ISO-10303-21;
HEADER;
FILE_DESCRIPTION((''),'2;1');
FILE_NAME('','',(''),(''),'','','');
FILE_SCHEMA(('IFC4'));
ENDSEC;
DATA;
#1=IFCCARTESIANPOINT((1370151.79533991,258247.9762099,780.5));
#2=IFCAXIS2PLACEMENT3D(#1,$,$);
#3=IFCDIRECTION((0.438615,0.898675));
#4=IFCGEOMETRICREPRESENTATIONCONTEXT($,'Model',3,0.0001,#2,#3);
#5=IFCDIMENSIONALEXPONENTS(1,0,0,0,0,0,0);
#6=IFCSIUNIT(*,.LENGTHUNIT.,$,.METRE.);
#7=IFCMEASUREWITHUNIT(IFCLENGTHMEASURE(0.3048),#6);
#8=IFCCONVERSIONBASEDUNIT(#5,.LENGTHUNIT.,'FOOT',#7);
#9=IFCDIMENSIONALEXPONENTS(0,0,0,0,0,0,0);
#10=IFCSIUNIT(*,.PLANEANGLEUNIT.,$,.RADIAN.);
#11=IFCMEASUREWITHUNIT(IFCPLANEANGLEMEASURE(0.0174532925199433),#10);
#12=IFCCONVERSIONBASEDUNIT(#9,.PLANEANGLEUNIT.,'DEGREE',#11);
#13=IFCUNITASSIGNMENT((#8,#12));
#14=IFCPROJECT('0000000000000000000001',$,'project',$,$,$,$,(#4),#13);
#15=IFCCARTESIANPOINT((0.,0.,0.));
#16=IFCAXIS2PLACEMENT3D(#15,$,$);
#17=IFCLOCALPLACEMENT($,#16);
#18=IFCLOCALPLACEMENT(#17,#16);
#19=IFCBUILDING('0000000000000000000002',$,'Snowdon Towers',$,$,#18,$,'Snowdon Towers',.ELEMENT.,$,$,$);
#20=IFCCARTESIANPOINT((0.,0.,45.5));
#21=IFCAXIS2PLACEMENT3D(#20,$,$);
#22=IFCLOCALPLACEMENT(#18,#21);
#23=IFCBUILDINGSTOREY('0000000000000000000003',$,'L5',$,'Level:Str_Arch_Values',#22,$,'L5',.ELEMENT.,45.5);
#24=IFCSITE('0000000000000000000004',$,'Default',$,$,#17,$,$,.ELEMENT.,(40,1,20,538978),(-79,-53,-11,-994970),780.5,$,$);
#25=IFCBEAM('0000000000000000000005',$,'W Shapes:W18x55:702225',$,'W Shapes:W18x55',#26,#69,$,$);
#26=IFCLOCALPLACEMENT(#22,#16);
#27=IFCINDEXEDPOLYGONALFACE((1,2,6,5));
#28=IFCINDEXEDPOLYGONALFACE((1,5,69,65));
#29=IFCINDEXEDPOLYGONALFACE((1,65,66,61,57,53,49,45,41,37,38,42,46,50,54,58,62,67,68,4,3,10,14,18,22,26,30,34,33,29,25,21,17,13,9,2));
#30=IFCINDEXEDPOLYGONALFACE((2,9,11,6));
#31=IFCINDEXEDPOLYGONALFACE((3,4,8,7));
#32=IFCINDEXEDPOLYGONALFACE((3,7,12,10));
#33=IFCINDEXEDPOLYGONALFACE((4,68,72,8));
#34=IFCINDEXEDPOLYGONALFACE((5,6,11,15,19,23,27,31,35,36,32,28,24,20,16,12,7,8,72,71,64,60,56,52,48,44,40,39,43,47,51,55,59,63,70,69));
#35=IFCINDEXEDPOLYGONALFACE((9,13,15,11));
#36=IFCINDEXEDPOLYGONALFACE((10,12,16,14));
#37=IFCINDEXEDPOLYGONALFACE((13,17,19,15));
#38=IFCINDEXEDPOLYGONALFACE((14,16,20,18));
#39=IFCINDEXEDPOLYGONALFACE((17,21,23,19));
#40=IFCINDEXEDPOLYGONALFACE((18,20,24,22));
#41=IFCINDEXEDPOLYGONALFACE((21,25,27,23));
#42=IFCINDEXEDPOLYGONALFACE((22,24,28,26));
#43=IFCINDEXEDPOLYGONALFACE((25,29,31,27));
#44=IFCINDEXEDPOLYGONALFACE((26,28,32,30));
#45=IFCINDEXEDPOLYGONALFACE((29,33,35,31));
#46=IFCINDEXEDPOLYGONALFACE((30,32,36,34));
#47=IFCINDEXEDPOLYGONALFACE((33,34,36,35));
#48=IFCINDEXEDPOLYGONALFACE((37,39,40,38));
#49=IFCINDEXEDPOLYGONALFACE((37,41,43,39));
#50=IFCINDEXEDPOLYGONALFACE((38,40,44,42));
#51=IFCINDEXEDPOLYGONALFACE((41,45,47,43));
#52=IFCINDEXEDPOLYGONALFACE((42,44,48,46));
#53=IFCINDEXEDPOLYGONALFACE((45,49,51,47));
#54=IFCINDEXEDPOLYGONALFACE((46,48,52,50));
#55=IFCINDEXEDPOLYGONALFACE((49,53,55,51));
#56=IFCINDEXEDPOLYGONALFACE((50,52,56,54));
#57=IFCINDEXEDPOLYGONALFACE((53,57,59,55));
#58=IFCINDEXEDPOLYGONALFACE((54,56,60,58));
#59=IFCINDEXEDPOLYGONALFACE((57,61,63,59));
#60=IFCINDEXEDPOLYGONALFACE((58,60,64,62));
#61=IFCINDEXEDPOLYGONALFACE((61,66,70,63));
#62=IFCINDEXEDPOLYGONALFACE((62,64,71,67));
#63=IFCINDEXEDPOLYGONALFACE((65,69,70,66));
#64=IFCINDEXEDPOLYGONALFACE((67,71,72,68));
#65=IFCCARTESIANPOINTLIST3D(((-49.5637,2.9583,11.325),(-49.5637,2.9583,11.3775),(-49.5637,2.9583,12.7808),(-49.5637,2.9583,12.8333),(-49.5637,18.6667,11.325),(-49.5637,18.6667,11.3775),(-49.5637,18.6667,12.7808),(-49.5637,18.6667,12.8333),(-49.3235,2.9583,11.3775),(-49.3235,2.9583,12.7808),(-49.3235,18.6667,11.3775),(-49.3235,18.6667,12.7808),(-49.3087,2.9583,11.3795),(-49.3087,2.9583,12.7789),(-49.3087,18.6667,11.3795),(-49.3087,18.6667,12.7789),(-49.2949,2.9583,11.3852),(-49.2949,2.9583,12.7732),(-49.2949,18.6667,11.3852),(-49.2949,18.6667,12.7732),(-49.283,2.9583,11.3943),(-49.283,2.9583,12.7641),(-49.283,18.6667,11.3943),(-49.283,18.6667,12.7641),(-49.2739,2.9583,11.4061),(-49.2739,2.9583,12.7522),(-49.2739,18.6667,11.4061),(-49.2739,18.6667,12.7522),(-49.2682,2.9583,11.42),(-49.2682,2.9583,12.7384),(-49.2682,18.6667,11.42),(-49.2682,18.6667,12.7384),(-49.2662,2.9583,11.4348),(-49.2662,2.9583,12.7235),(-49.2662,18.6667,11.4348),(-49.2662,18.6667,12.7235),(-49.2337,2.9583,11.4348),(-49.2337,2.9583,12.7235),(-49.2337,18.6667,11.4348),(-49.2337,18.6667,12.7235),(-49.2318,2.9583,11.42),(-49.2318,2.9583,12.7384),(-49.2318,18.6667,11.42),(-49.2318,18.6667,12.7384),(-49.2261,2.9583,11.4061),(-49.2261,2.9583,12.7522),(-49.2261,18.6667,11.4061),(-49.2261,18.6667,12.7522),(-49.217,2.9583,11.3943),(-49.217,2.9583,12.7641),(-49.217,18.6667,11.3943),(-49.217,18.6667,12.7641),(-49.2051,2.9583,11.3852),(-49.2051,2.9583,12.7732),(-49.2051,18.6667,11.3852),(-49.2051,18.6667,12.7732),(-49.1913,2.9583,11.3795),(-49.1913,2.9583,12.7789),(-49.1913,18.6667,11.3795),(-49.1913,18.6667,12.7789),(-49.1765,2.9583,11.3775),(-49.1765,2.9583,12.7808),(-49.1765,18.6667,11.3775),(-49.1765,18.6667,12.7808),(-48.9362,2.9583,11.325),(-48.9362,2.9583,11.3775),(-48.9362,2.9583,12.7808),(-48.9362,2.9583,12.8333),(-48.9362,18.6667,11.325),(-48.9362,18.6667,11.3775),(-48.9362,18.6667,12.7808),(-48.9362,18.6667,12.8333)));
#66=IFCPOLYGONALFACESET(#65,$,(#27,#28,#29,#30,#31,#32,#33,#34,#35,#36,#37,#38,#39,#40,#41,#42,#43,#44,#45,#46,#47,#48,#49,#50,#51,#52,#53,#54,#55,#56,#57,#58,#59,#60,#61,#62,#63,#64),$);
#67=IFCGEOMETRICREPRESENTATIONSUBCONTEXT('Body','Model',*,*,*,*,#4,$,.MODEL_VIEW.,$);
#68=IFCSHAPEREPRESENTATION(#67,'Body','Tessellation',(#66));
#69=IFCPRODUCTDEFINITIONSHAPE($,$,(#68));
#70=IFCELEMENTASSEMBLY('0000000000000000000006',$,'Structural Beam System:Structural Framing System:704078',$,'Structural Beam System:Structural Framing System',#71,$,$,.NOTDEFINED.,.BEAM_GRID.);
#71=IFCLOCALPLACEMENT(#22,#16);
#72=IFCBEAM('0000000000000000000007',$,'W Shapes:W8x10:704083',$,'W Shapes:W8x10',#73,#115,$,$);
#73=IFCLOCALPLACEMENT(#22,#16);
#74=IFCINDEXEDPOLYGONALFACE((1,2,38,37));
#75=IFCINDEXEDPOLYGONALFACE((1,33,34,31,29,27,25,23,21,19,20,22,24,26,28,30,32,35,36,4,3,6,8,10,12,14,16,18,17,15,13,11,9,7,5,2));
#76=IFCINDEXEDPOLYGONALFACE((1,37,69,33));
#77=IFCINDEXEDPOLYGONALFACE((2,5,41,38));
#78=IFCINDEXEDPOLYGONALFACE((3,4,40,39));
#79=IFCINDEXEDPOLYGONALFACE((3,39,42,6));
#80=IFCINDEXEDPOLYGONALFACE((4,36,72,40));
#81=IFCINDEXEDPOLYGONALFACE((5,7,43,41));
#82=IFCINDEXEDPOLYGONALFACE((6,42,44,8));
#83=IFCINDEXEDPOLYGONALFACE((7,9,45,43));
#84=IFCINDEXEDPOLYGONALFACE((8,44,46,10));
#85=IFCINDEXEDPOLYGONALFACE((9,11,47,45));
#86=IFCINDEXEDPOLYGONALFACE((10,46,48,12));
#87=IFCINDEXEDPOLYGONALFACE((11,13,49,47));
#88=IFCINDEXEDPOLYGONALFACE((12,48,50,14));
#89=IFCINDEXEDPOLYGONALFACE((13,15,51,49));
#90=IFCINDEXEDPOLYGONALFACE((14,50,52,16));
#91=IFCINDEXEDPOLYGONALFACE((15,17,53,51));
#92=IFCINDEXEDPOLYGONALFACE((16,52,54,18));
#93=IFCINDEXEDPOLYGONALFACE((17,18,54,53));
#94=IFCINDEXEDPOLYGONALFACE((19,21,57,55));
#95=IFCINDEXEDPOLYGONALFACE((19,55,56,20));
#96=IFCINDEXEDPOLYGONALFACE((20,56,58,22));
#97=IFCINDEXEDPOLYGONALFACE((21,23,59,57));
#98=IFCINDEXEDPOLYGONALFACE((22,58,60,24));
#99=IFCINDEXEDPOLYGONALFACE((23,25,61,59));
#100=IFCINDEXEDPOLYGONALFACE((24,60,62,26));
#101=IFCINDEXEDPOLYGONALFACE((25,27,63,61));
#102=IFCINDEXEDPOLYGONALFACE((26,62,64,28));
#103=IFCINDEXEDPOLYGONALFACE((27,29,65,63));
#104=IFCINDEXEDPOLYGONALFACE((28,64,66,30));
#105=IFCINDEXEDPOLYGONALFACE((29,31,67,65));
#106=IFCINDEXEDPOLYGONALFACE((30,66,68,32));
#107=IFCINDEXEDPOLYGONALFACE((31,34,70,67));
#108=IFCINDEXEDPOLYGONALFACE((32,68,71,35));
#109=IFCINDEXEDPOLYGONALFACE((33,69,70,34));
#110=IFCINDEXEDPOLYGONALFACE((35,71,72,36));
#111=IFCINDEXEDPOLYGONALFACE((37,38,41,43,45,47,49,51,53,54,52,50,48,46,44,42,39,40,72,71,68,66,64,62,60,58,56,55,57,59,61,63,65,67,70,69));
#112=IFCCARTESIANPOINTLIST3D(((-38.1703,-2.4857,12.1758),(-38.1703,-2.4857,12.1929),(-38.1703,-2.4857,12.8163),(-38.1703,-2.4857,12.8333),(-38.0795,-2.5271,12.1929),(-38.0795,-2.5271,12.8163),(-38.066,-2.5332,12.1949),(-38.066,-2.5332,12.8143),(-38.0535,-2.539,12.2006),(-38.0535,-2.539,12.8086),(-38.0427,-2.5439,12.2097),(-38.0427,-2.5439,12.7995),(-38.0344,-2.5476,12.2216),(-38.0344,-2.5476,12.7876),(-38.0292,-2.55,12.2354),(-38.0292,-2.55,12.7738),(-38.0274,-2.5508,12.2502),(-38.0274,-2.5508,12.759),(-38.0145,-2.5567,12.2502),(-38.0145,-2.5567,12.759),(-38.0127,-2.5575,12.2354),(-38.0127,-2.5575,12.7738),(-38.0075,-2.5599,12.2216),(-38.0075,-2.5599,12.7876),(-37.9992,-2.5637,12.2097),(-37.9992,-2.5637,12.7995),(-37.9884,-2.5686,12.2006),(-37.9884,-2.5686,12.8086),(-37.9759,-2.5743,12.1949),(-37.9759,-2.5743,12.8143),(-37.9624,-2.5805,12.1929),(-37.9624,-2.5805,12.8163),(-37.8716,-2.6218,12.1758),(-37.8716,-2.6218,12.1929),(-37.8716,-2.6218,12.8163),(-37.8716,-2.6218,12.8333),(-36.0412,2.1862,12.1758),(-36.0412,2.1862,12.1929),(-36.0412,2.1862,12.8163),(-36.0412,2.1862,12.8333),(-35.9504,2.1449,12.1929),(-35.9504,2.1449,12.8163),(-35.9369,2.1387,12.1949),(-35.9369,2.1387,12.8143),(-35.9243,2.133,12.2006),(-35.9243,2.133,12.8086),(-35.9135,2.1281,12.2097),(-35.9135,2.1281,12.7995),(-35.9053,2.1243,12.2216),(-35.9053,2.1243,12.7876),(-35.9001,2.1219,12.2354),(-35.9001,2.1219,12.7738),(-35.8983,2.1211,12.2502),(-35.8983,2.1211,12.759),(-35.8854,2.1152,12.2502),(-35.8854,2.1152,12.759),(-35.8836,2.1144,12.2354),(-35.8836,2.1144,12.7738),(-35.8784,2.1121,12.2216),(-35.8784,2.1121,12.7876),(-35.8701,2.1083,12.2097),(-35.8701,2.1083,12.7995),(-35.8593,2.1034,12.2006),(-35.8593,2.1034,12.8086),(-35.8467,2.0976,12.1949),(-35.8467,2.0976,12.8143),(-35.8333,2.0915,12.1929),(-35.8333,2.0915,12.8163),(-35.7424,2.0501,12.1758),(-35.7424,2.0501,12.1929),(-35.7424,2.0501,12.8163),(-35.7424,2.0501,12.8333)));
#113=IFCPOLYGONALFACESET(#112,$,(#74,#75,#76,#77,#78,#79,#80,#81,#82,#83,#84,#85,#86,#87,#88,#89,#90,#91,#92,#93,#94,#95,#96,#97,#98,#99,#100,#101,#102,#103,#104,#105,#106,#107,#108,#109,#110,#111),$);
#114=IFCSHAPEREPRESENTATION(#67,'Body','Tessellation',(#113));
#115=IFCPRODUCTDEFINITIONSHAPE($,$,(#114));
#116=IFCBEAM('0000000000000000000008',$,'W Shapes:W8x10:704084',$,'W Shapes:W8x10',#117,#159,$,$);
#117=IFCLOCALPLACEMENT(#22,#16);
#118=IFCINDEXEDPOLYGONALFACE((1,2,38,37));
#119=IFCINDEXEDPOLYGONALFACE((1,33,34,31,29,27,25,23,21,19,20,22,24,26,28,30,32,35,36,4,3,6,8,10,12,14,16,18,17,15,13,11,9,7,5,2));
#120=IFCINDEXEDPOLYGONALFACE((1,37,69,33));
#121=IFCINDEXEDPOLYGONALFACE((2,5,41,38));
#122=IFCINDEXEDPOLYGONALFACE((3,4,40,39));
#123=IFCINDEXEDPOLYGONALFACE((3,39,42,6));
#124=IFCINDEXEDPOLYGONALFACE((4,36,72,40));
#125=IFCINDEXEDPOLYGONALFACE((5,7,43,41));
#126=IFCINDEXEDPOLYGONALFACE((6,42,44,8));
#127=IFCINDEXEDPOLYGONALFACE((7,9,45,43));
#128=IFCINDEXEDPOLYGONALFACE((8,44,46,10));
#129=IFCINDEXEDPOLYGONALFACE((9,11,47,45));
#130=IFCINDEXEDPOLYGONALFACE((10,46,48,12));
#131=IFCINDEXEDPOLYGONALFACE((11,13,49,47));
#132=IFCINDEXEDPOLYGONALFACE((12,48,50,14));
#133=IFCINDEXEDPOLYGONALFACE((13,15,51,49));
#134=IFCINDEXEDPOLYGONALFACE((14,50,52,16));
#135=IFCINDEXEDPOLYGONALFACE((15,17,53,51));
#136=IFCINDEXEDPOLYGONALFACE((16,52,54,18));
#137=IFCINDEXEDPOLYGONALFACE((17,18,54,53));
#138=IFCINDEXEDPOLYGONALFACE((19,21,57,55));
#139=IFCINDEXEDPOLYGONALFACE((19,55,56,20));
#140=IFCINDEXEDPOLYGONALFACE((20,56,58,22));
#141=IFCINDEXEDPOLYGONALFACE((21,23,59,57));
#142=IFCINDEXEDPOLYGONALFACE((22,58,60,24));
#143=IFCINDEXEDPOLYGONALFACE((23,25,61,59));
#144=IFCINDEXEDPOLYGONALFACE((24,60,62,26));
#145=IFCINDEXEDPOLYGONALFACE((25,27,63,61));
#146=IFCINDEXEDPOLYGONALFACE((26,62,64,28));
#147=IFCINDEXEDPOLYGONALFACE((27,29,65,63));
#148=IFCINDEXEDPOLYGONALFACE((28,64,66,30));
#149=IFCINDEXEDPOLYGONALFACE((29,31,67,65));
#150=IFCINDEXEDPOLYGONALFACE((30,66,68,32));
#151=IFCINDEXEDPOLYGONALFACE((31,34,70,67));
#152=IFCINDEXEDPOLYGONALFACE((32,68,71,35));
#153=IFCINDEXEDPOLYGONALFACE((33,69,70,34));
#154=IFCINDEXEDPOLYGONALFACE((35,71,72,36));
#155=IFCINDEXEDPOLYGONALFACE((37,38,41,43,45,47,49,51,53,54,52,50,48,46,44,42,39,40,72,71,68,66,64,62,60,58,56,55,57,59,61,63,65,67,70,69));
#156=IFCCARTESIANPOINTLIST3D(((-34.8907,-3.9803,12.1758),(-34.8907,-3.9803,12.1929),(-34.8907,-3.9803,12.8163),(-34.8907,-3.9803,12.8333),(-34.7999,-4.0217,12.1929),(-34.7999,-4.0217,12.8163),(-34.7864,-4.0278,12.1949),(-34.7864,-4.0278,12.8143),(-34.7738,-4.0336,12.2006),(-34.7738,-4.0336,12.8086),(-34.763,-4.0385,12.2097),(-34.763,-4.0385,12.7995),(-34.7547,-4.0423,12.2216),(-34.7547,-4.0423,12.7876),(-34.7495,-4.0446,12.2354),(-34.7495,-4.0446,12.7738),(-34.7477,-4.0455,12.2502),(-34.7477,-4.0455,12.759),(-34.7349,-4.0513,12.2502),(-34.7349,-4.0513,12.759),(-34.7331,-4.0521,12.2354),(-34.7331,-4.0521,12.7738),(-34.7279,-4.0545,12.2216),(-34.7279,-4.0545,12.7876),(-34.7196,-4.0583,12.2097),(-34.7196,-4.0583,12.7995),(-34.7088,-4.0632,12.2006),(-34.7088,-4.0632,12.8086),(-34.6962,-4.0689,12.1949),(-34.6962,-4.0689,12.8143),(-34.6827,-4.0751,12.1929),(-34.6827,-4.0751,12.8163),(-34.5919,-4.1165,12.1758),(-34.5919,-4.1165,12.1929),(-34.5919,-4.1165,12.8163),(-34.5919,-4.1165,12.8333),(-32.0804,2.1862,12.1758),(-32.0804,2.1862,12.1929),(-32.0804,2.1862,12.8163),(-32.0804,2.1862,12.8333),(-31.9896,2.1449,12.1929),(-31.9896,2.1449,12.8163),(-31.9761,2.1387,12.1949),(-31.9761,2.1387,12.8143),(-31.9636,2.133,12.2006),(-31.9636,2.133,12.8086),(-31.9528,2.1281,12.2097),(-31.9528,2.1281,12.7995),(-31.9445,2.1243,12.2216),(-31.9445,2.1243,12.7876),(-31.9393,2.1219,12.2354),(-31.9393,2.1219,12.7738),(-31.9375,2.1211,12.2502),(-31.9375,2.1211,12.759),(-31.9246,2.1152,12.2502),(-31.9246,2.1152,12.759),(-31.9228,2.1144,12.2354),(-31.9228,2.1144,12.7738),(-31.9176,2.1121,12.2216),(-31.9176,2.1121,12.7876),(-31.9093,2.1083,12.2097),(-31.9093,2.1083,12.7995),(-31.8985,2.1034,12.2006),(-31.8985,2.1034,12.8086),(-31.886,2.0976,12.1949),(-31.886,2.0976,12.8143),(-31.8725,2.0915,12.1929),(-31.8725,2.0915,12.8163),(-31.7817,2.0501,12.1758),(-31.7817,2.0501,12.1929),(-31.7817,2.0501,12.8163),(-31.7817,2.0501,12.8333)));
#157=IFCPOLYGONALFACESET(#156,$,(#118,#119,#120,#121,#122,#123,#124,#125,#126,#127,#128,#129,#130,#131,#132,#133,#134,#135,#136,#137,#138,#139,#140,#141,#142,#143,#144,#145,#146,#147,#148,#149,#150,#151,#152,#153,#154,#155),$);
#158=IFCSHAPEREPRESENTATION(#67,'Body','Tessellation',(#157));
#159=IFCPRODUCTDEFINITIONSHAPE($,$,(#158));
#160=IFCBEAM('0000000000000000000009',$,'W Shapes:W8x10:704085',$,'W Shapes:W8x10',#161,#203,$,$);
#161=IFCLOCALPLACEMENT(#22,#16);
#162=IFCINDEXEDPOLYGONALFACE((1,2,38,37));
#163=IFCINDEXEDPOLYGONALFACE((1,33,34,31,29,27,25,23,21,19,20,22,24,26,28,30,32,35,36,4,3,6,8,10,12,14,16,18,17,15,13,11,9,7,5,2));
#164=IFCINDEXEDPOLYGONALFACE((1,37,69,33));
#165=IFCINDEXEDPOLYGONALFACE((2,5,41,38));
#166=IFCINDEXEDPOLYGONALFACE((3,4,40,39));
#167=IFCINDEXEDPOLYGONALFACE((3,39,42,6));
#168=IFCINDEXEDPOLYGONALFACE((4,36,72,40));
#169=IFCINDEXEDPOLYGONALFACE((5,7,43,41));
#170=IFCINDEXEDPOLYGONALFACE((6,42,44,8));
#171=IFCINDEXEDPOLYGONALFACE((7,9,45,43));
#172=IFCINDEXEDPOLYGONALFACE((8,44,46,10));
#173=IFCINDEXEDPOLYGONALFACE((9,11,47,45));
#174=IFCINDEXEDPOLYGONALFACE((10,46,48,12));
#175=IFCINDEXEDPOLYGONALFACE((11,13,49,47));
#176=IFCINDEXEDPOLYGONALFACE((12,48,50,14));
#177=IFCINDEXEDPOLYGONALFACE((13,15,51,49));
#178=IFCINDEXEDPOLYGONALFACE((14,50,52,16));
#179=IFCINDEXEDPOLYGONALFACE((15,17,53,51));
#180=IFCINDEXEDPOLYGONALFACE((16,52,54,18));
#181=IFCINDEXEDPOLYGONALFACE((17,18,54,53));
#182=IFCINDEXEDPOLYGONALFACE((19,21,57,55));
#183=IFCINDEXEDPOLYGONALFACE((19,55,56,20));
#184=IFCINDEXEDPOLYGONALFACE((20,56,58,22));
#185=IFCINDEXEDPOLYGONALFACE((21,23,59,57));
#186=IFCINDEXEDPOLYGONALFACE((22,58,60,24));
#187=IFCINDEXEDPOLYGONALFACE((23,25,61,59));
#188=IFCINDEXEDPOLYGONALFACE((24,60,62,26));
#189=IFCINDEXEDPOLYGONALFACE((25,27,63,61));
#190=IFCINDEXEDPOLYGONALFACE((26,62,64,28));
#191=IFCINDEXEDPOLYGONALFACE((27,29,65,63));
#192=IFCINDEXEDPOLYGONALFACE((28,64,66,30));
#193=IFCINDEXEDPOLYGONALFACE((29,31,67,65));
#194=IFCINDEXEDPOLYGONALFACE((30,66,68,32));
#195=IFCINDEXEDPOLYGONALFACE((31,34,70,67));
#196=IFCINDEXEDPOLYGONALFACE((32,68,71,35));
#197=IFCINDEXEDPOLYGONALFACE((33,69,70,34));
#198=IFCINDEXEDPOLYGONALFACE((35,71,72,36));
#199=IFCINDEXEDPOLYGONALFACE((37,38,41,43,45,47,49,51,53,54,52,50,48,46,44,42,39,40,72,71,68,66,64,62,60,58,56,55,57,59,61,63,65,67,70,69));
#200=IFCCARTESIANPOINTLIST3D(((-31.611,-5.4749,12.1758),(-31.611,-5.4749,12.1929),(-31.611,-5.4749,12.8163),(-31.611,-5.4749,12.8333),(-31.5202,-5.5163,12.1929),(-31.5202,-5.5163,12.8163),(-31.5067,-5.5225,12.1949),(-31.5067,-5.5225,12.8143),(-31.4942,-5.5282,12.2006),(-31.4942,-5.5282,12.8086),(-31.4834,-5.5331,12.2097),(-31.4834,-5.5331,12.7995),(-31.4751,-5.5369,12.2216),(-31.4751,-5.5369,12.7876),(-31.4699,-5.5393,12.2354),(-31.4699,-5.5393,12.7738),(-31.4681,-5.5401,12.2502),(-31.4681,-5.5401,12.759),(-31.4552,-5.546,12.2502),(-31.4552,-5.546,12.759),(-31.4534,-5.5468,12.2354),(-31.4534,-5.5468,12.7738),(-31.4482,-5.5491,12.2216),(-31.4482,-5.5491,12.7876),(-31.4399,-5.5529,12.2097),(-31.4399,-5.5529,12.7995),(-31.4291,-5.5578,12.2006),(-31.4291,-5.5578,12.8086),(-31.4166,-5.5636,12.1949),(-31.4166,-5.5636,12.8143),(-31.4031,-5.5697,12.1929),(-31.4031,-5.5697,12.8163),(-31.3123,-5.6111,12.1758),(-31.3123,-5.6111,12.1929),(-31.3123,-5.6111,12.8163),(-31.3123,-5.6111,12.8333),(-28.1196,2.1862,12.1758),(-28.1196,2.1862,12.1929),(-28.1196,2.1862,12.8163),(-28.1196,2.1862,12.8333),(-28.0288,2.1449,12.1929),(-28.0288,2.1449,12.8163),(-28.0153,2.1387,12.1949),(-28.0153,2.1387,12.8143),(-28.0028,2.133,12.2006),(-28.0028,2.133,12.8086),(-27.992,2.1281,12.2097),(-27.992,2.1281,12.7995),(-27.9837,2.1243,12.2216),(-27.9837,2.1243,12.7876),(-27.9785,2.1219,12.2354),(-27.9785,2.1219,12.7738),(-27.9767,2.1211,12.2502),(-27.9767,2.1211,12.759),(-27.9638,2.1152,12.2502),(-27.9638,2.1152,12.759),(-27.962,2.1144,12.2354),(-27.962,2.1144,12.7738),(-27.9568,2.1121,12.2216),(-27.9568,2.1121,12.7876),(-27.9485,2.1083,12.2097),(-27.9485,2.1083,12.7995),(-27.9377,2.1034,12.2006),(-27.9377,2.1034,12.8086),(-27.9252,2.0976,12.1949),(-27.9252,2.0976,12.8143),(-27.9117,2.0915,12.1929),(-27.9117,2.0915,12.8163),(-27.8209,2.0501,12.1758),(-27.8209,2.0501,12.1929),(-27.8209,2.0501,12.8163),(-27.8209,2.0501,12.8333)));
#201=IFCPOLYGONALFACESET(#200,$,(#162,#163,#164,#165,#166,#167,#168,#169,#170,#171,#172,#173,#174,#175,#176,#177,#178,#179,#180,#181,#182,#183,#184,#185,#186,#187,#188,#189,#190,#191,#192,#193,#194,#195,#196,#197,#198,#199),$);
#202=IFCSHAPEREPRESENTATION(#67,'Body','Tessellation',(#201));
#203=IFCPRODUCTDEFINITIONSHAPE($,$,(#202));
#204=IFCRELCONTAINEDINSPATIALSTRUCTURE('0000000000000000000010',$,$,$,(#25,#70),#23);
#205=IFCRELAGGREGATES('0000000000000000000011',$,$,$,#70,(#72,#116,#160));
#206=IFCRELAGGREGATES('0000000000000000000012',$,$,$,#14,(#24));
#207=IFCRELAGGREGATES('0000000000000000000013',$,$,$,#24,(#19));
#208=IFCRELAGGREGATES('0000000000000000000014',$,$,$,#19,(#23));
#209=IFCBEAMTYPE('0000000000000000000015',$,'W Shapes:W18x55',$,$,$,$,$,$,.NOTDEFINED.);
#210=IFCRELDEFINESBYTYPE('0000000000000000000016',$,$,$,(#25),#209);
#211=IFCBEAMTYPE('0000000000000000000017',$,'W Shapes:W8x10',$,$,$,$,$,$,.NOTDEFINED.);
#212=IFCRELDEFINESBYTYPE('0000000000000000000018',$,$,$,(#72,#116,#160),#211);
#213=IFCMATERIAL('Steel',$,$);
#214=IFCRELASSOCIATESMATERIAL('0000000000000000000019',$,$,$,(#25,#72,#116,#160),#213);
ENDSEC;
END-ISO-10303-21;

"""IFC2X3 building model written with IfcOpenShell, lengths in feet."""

from ifc_helpers import new_model, entity, si_unit, converted_unit, direction, frame, frame_2d, origin, place, context, subcontext, project, spatial, i_section, extrude, material, type_object, element, aggregate, save


model = new_model("IFC2X3")

# Units and contexts
model_context = context("Model", 3, precision=0.0001, world=frame((1370151.79533991, 258247.9762099, 780.5)), true_north=direction((0.438615, 0.898675)))
body_context = subcontext(model_context, "Body", "Model", "MODEL_VIEW")
ifc_project = project(units=[converted_unit("LENGTHUNIT", "FOOT", entity("IfcLengthMeasure", 0.3048), si_unit("LENGTHUNIT", "METRE"), dimensions=[1, 0, 0, 0, 0, 0, 0]), converted_unit("PLANEANGLEUNIT", "DEGREE", entity("IfcPlaneAngleMeasure", 0.0174532925199433), si_unit("PLANEANGLEUNIT", "RADIAN"), dimensions=[0, 0, 0, 0, 0, 0, 0])], contexts=[model_context])

# Site, building, storey
site_placement = place(None, origin())
site = spatial("IfcSite", under=ifc_project, at=site_placement, Name="Default", CompositionType="ELEMENT", RefLatitude=(40, 1, 20, 538978), RefLongitude=(-79, -53, -11, -994970), RefElevation=780.5)
building_placement = place(site_placement, origin())
building = spatial("IfcBuilding", under=site, at=building_placement, Name="Snowdon Towers", LongName="Snowdon Towers", CompositionType="ELEMENT")
storey_placement = place(building_placement, frame((0.0, 0.0, 45.5)))
storey = spatial("IfcBuildingStorey", under=building, at=storey_placement, Name="L5", ObjectType="Level:Str_Arch_Values", LongName="L5", CompositionType="ELEMENT", Elevation=45.5)

# Beam
ifc_material_1 = material(Name="Steel")
beam_type_1 = type_object("IfcBeamType", Name="W Shapes:W18x55", PredefinedType="NOTDEFINED")
beam_1_placement = place(storey_placement, frame((-49.25, 19.2083, 12.8333), z_axis=(0.0, 0.0, 1.0), x_axis=(0.0, -1.0, 0.0)))
element("IfcBeam", 1, at=beam_1_placement, inside=storey, type_object=beam_type_1, material=ifc_material_1, Name="W Shapes:W18x55:702225", ObjectType="W Shapes:W18x55", context=body_context, shape_type="SweptSolid", body=[
    extrude(i_section(OverallWidth=0.6275, OverallDepth=1.5083, WebThickness=0.0325, FlangeThickness=0.0525, FilletRadius=0.0573, at=frame_2d((0.0, 0.0), x_axis=(0.0, 1.0))), frame((0.5417, 0.0, -0.7542), z_axis=(1.0, 0.0, 0.0), x_axis=(0.0, 0.0, -1.0)), (0.0, 0.0, 1.0), 15.7083),
])

# Element assembly, beams
assembly_1_placement = place(storey_placement, origin())
assembly_1 = element("IfcElementAssembly", 2, at=assembly_1_placement, inside=storey, Name="Structural Beam System:Structural Framing System:704078", ObjectType="Structural Beam System:Structural Framing System", AssemblyPlace="NOTDEFINED", PredefinedType="BEAM_GRID")
beam_type_2 = type_object("IfcBeamType", Name="W Shapes:W8x10", PredefinedType="NOTDEFINED")
beam_2_placement = place(assembly_1_placement, frame((-38.1331, -2.7998, 12.8333), z_axis=(0.0, 0.0, 1.0), x_axis=(0.414693, 0.909961, 0.0)))
beam_2 = element("IfcBeam", 3, at=beam_2_placement, type_object=beam_type_2, material=ifc_material_1, Name="W Shapes:W8x10:704083", ObjectType="W Shapes:W8x10", context=body_context, shape_type="SweptSolid", body=[
    extrude(i_section(OverallWidth=0.3283, OverallDepth=0.6575, WebThickness=0.0142, FlangeThickness=0.0171, FilletRadius=0.0573, at=frame_2d((0.0, 0.0), x_axis=(0.0, 1.0))), frame((0.2704, 0.0, -0.3288), z_axis=(1.0, 0.0, 0.0), x_axis=(0.0, 0.0, -1.0)), (0.0, 0.0, 1.0), 5.1342),
])
beam_3_placement = place(assembly_1_placement, frame((-34.8534, -4.2945, 12.8333), z_axis=(0.0, 0.0, 1.0), x_axis=(0.414693, 0.909961, 0.0)))
beam_3 = element("IfcBeam", 4, at=beam_3_placement, type_object=beam_type_2, material=ifc_material_1, Name="W Shapes:W8x10:704084", ObjectType="W Shapes:W8x10", context=body_context, shape_type="SweptSolid", body=[
    extrude(i_section(OverallWidth=0.3283, OverallDepth=0.6575, WebThickness=0.0142, FlangeThickness=0.0171, FilletRadius=0.0573, at=frame_2d((0.0, 0.0), x_axis=(0.0, 1.0))), frame((0.2704, 0.0, -0.3288), z_axis=(1.0, 0.0, 0.0), x_axis=(0.0, 0.0, -1.0)), (0.0, 0.0, 1.0), 6.7767),
])
beam_4_placement = place(assembly_1_placement, frame((-31.5738, -5.7891, 12.8333), z_axis=(0.0, 0.0, 1.0), x_axis=(0.414693, 0.909961, 0.0)))
beam_4 = element("IfcBeam", 5, at=beam_4_placement, type_object=beam_type_2, material=ifc_material_1, Name="W Shapes:W8x10:704085", ObjectType="W Shapes:W8x10", context=body_context, shape_type="SweptSolid", body=[
    extrude(i_section(OverallWidth=0.3283, OverallDepth=0.6575, WebThickness=0.0142, FlangeThickness=0.0171, FilletRadius=0.0573, at=frame_2d((0.0, 0.0), x_axis=(0.0, 1.0))), frame((0.2704, 0.0, -0.3288), z_axis=(1.0, 0.0, 0.0), x_axis=(0.0, 0.0, -1.0)), (0.0, 0.0, 1.0), 8.4192),
])
aggregate(assembly_1, [beam_2, beam_3, beam_4])

save(model, "model.ifc")
